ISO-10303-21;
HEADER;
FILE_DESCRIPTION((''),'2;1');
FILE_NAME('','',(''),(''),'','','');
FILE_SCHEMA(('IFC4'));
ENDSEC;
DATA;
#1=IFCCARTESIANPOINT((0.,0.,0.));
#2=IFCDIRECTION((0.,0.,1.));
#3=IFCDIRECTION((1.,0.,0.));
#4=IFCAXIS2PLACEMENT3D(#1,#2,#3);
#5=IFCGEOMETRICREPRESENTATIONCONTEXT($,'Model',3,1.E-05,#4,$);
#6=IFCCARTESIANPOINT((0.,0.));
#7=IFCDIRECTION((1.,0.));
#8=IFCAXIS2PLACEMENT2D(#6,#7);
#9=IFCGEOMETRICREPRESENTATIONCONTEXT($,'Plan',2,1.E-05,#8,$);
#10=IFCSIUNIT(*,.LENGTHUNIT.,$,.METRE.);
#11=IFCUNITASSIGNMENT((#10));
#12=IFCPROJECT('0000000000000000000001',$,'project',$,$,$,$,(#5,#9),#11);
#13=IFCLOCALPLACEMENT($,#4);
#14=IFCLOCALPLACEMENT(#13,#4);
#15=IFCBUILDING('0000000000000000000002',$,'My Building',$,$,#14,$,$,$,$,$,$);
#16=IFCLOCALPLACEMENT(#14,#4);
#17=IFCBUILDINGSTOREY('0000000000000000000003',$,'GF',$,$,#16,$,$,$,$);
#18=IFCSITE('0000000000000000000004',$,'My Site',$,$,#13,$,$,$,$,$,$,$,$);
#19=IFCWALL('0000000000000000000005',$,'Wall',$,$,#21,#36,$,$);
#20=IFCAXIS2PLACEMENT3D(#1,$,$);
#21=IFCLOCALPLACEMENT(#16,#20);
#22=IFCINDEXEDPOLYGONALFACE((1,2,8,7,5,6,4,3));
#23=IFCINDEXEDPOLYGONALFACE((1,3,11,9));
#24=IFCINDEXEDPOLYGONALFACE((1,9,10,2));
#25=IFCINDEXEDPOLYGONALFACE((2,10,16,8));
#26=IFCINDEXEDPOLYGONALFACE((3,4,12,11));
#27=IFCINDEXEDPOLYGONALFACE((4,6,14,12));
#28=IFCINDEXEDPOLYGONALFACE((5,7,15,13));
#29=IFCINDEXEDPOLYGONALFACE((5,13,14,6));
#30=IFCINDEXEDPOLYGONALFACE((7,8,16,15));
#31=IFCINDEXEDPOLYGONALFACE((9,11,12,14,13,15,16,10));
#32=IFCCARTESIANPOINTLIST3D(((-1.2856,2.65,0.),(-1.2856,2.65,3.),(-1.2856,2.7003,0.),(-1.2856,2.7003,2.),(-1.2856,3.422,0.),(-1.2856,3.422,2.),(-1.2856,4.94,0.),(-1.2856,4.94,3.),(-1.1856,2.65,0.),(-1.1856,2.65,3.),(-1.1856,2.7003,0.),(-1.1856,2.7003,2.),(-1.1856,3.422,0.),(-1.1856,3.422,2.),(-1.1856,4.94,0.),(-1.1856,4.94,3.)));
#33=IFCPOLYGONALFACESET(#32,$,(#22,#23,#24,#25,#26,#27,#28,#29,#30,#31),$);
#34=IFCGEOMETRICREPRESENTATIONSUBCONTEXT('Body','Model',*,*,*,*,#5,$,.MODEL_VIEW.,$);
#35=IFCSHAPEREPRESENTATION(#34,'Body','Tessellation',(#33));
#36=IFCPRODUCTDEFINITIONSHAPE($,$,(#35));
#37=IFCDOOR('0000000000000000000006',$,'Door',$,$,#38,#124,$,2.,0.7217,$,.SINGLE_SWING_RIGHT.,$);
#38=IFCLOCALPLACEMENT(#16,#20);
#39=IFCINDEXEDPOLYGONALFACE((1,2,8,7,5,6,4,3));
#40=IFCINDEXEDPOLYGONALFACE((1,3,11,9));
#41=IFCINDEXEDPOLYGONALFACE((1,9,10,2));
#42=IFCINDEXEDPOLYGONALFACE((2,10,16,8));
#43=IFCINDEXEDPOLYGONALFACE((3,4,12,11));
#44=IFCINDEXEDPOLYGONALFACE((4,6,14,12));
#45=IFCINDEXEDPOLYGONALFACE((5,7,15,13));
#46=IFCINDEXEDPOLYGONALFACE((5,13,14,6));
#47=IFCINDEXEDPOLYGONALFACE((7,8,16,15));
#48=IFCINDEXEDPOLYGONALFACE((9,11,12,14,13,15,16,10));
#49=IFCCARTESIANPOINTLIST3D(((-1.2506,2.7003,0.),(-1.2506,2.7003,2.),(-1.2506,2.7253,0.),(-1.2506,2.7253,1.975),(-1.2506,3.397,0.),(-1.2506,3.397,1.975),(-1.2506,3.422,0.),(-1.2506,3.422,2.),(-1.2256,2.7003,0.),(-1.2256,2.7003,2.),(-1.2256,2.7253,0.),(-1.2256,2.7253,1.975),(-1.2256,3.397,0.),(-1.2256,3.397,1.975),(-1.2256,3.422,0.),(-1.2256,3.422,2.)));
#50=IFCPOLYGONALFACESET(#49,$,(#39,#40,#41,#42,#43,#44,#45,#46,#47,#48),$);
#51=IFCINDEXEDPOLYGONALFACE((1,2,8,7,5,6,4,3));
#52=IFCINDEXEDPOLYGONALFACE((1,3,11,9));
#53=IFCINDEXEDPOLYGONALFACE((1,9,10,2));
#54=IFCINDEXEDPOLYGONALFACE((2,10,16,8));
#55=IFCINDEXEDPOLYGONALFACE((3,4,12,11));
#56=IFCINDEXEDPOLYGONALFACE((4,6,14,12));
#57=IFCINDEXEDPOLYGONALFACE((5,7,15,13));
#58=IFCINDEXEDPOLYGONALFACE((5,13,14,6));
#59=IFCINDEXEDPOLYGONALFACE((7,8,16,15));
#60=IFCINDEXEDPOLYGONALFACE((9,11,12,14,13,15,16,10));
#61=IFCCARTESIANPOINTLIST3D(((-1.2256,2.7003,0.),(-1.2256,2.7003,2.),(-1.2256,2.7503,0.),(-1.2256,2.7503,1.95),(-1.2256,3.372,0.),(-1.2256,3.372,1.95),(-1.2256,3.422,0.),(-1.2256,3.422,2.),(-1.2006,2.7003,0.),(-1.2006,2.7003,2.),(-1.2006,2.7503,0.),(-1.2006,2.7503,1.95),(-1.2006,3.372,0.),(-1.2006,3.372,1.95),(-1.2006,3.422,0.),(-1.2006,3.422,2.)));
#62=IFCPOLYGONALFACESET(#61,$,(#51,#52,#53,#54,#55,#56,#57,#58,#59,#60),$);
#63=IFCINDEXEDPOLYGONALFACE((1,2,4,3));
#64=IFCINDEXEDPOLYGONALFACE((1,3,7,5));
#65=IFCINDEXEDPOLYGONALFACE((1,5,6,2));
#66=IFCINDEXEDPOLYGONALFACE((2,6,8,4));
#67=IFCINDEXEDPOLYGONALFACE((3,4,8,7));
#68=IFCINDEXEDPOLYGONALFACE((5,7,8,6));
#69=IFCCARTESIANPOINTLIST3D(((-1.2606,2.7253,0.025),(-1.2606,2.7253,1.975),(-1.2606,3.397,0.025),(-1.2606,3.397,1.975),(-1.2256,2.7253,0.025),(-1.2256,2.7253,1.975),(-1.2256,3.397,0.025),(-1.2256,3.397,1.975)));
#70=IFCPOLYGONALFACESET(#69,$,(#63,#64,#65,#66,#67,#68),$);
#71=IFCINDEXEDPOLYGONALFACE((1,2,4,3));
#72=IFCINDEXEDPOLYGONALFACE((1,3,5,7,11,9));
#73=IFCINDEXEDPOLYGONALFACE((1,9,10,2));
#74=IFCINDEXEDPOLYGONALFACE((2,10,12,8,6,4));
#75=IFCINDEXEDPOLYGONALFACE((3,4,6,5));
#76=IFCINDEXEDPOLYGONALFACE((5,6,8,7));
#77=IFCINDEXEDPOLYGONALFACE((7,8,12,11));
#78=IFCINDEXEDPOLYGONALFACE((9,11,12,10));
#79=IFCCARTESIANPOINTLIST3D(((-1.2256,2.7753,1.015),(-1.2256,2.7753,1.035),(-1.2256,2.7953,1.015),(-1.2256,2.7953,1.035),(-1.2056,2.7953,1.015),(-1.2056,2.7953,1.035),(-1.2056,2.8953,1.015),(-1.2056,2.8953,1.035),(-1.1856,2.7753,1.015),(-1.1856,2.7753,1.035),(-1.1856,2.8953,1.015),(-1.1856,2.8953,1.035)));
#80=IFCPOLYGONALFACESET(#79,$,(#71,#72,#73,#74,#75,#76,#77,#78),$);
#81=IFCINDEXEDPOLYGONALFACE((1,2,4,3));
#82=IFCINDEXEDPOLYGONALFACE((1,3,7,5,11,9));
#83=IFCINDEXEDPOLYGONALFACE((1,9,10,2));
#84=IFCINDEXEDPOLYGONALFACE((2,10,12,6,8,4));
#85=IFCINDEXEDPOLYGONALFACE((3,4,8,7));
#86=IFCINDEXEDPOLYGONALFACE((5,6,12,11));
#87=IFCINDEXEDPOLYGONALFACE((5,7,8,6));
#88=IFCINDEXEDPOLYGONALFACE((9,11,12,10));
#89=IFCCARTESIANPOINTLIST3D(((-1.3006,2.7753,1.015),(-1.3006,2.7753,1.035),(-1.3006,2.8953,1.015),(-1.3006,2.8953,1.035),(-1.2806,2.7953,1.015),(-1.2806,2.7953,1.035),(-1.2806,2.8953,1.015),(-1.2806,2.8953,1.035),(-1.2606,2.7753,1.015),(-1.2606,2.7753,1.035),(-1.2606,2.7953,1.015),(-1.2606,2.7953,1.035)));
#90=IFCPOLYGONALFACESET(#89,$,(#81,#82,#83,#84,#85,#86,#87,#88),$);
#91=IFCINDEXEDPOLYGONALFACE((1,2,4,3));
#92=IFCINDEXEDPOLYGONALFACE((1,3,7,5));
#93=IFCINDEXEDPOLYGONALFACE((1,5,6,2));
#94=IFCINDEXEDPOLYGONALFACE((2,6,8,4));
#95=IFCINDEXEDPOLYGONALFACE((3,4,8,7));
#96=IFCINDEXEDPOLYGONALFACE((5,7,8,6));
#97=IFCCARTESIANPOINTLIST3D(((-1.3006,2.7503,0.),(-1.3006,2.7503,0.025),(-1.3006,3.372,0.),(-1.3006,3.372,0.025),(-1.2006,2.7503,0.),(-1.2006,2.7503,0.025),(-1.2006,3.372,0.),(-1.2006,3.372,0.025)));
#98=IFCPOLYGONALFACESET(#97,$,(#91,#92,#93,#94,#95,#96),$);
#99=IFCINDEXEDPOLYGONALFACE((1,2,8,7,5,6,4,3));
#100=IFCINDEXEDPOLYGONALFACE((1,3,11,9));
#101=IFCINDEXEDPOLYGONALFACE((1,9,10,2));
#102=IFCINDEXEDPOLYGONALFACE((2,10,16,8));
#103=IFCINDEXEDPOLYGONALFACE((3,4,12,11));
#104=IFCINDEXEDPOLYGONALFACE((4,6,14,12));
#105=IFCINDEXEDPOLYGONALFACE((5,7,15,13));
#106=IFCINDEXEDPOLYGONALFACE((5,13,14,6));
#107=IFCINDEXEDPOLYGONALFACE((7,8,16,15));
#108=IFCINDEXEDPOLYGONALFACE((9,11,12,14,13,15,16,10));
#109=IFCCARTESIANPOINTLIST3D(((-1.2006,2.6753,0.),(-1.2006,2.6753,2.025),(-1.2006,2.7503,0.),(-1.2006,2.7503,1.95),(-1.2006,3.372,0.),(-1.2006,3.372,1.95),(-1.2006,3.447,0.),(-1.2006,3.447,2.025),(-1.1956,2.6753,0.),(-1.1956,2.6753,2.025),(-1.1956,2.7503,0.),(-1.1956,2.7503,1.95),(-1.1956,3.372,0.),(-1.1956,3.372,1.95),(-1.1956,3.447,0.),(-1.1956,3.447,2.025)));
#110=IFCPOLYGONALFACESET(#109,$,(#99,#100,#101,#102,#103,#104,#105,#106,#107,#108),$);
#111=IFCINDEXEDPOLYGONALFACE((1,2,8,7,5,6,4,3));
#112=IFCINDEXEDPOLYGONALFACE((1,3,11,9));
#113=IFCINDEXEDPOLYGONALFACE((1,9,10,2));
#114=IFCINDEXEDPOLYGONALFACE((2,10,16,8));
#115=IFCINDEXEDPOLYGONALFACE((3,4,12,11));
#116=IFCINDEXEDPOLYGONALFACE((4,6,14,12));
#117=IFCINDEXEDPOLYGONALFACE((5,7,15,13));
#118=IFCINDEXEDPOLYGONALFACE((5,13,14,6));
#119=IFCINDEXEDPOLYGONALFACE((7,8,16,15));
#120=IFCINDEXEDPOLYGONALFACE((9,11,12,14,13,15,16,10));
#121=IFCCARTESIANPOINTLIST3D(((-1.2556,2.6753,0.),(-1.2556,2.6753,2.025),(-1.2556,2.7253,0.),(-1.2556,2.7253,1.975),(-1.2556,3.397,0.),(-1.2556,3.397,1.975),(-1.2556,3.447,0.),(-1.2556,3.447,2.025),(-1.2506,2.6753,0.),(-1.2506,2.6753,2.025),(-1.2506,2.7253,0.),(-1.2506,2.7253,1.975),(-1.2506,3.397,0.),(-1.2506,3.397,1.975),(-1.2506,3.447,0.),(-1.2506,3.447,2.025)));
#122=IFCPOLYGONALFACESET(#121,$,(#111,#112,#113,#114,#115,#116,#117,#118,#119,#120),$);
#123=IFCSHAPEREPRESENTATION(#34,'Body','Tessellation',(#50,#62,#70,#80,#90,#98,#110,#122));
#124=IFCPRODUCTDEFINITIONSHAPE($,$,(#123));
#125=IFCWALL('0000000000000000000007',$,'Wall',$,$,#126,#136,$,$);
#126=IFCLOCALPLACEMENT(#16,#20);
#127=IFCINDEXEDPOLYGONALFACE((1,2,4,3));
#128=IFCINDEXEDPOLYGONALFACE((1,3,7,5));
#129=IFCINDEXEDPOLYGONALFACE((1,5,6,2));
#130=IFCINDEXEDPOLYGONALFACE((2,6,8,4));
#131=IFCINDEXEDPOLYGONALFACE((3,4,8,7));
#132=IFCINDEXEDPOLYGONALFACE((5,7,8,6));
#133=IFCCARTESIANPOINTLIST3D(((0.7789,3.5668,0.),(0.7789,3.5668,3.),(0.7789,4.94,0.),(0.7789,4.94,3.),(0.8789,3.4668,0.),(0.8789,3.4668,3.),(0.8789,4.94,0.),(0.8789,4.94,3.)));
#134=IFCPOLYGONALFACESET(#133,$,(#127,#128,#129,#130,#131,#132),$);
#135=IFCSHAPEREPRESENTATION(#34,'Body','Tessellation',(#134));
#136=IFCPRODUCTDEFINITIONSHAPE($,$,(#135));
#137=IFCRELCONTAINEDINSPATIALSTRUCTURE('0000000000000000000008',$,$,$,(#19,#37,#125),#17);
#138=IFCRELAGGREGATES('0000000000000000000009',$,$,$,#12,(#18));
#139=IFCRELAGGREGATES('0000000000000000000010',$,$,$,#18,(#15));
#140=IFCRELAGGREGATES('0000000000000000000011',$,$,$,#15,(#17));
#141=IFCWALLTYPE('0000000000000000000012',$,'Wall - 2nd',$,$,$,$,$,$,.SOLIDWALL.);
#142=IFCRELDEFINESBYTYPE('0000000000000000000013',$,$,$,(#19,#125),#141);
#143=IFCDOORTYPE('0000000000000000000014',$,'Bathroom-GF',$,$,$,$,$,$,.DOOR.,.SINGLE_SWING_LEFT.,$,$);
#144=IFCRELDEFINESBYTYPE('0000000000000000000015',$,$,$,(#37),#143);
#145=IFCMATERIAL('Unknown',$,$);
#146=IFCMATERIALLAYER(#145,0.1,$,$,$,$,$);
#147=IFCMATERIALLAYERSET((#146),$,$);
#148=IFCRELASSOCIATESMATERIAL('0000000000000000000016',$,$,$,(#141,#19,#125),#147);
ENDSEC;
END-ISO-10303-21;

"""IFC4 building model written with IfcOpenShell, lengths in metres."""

from ifc_helpers import new_model, entity, si_unit, frame, origin_with_axes, origin_2d_with_axis, place, context, subcontext, project, spatial, line, indexed_curve, outline, extrude, shape, source, transform, mapped, material, layer, layer_set, layer_usage, type_object, type_shapes, element, fill, save


model = new_model("IFC4")

# Units and contexts
model_context = context("Model", 3, precision=1e-05, world=origin_with_axes())
plan_context = context("Plan", 2, precision=1e-05, world=origin_2d_with_axis())
body_context_1 = subcontext(model_context, "Body", "Model", "MODEL_VIEW")
body_context_2 = subcontext(plan_context, "Body", "Plan", "PLAN_VIEW")
ifc_project = project(units=[si_unit("LENGTHUNIT", "METRE")], contexts=[model_context, plan_context])

# Site, building, storey
site_placement = place(None, origin_with_axes())
site = spatial("IfcSite", under=ifc_project, at=site_placement, Name="My Site")
building_placement = place(site_placement, origin_with_axes())
building = spatial("IfcBuilding", under=site, at=building_placement, Name="My Building")
storey_placement = place(building_placement, origin_with_axes())
storey = spatial("IfcBuildingStorey", under=building, at=storey_placement, Name="GF")

# Shared definitions
ifc_material = material(Name="Unknown")

# Shared definitions
ifc_layer_1 = layer(ifc_material, 0.1)
ifc_layer_set_1 = layer_set([ifc_layer_1])
wall_type = type_object("IfcWallType", Name="Wall - 2nd", PredefinedType="SOLIDWALL", material=ifc_layer_set_1)

# Wall, opening, door
ifc_layer_usage_1 = layer_usage(ifc_layer_set_1, "AXIS2", "POSITIVE", 0.0)
wall_1_placement = place(storey_placement, frame((-1.1856, 2.65, 0.0), z_axis=(0.0, 0.0, 1.0), x_axis=(0.0, 1.0, 0.0)))
wall_1 = element("IfcWall", 1, at=wall_1_placement, inside=storey, type_object=wall_type, material=ifc_layer_usage_1, Name="Wall", context=body_context_1, shape_type="SweptSolid", body=[
    extrude(outline(indexed_curve([(0.0, 0.0), (0.0, 0.1), (2.29, 0.1), (2.29, 0.0)], segments=[line(1, 2, 3, 4, 1)])), origin_with_axes(), (0.0, 0.0, 1.0), 3.0),
])
shared_shape_1 = source(origin_with_axes(), body_context_1, "Body", "SweptSolid", [
    extrude(outline(indexed_curve([(0.0, 0.0), (0.7217, 0.0), (0.7217, 2.0), (0.0, 2.0)], segments=[line(1, 2, 3, 4, 1)])), frame((0.0, -0.6, 0.0), z_axis=(0.0, -1.0, 0.0), x_axis=(1.0, 0.0, 0.0)), (0.0, 0.0, -1.0), 1.2),
])
opening_1_placement = place(wall_1_placement, frame((0.772, 0.1, 0.0), z_axis=(0.0, 0.0, 1.0), x_axis=(-1.0, 0.0, 0.0)))
opening_1 = element("IfcOpeningElement", 2, at=opening_1_placement, cuts=wall_1, PredefinedType="OPENING", context=body_context_1, shape_type="MappedRepresentation", body=[
    mapped(shared_shape_1, transform((0.0, 0.0, 0.0), x_axis=(1.0, 0.0, 0.0), y_axis=(0.0, 1.0, 0.0), z_axis=(0.0, 0.0, 1.0), scale=1.0)),
])
door_type_1 = type_object("IfcDoorType", Name="Bathroom-GF", OperationType="SINGLE_SWING_LEFT", PredefinedType="DOOR")
shared_shape_2 = source(origin_with_axes(), body_context_1, "Body", "SweptSolid", [
    extrude(outline(indexed_curve([(0.0, 0.0), (0.0, 2.0), (0.7217, 2.0), (0.7217, 0.0), (0.6967, 0.0), (0.6967, 1.975), (0.025, 1.975), (0.025, 0.0)], segments=[line(1, 2, 3, 4, 5, 6, 7, 8, 1)])), frame((0.0, 0.025, 0.0), z_axis=(0.0, -1.0, 0.0), x_axis=(1.0, 0.0, 0.0)), (0.0, 0.0, -1.0), 0.025),
    extrude(outline(indexed_curve([(0.0, 0.0), (0.0, 2.0), (0.7217, 2.0), (0.7217, 0.0), (0.6717, 0.0), (0.6717, 1.95), (0.05, 1.95), (0.05, 0.0)], segments=[line(1, 2, 3, 4, 5, 6, 7, 8, 1)])), frame((0.0, 0.0, 0.0), z_axis=(0.0, -1.0, 0.0), x_axis=(1.0, 0.0, 0.0)), (0.0, 0.0, -1.0), 0.025),
    extrude(outline(indexed_curve([(0.0, 0.0), (0.6717, 0.0), (0.6717, 0.035), (0.0, 0.035)], segments=[line(1, 2, 3, 4, 1)])), frame((0.025, 0.025, 0.025), z_axis=(0.0, 0.0, 1.0), x_axis=(1.0, 0.0, 0.0)), (0.0, 0.0, 1.0), 1.95),
    extrude(outline(indexed_curve([(0.0, 0.0), (0.0, -0.04), (0.12, -0.04), (0.12, -0.02), (0.02, -0.02), (0.02, 0.0)], segments=[line(1, 2, 3, 4, 5, 6, 1)])), frame((0.075, 0.025, 1.015), z_axis=(0.0, 0.0, 1.0), x_axis=(1.0, 0.0, 0.0)), (0.0, 0.0, 1.0), 0.02),
    extrude(outline(indexed_curve([(0.0, 0.0), (0.0, 0.04), (0.12, 0.04), (0.12, 0.02), (0.02, 0.02), (0.02, 0.0)], segments=[line(1, 2, 3, 4, 5, 6, 1)])), frame((0.075, 0.06, 1.015), z_axis=(0.0, 0.0, 1.0), x_axis=(1.0, 0.0, 0.0)), (0.0, 0.0, 1.0), 0.02),
    extrude(outline(indexed_curve([(0.0, 0.0), (0.6217, 0.0), (0.6217, 0.1), (0.0, 0.1)], segments=[line(1, 2, 3, 4, 1)])), frame((0.05, 0.0, 0.0), z_axis=(0.0, 0.0, 1.0), x_axis=(1.0, 0.0, 0.0)), (0.0, 0.0, 1.0), 0.025),
    extrude(outline(indexed_curve([(0.0, 0.0), (0.0, 2.025), (0.7717, 2.025), (0.7717, 0.0), (0.6967, 0.0), (0.6967, 1.95), (0.075, 1.95), (0.075, 0.0)], segments=[line(1, 2, 3, 4, 5, 6, 7, 8, 1)])), frame((-0.025, -0.005, 0.0), z_axis=(0.0, -1.0, 0.0), x_axis=(1.0, 0.0, 0.0)), (0.0, 0.0, -1.0), 0.005),
    extrude(outline(indexed_curve([(0.0, 0.0), (0.0, 2.025), (0.7717, 2.025), (0.7717, 0.0), (0.7217, 0.0), (0.7217, 1.975), (0.05, 1.975), (0.05, 0.0)], segments=[line(1, 2, 3, 4, 5, 6, 7, 8, 1)])), frame((-0.025, 0.05, 0.0), z_axis=(0.0, -1.0, 0.0), x_axis=(1.0, 0.0, 0.0)), (0.0, 0.0, -1.0), 0.005),
])
shared_shape_3 = source(origin_with_axes(), body_context_2, "Body", "Curve2D", [
    entity("IfcIndexedPolyCurve", entity("IfcCartesianPointList2D", [[0.0, 0.0], [0.0, 0.05], [0.025, 0.05], [0.025, 0.025], [0.05, 0.025], [0.05, 0.0]]), [entity("IfcLineIndex", [1, 2, 3, 4, 5, 6, 1])]),
    entity("IfcIndexedPolyCurve", entity("IfcCartesianPointList2D", [[0.7217, 0.0], [0.7217, 0.05], [0.6967, 0.05], [0.6967, 0.025], [0.6717, 0.025], [0.6717, 0.0]]), [entity("IfcLineIndex", [1, 2, 3, 4, 5, 6, 1])]),
    entity("IfcTrimmedCurve", entity("IfcEllipse", entity("IfcAxis2Placement2D", entity("IfcCartesianPoint", [0.6617, 0.05]), entity("IfcDirection", [1.0, 0.0])), 0.6367, 0.6717), [entity("IfcCartesianPoint", [0.6617, 0.7217])], [entity("IfcCartesianPoint", [0.025, 0.05])], True, "CARTESIAN"),
    entity("IfcIndexedPolyCurve", entity("IfcCartesianPointList2D", [[0.6967, 0.05], [0.6617, 0.05], [0.6617, 0.7217], [0.6967, 0.7217]]), [entity("IfcLineIndex", [1, 2, 3, 4, 1])]),
])
type_shapes(door_type_1, [shared_shape_2, shared_shape_3])
door_1_placement = place(opening_1_placement, frame((0.7217, 0.085, 0.0), z_axis=(0.0, 0.0, 1.0), x_axis=(-1.0, 0.0, 0.0)))
door_1 = element("IfcDoor", 3, at=door_1_placement, inside=storey, type_object=door_type_1, Name="Door", OperationType="SINGLE_SWING_RIGHT", OverallHeight=2.0, OverallWidth=0.7217, shapes=[
    shape(body_context_1, "Body", "MappedRepresentation", [mapped(shared_shape_2, transform((0.0, 0.0, 0.0), x_axis=(1.0, 0.0, 0.0), y_axis=(0.0, 1.0, 0.0), z_axis=(0.0, 0.0, 1.0), scale=1.0))]),
    shape(body_context_2, "Body", "MappedRepresentation", [mapped(shared_shape_3, transform((0.0, 0.0, 0.0), x_axis=(1.0, 0.0, 0.0), y_axis=(0.0, 1.0, 0.0), z_axis=(0.0, 0.0, 1.0), scale=1.0))]),
])
fill(opening_1, door_1)

# Wall
ifc_layer_usage_2 = layer_usage(ifc_layer_set_1, "AXIS2", "POSITIVE", 0.0)
wall_2_placement = place(storey_placement, frame((0.7789, 5.04, 0.0), z_axis=(0.0, 0.0, 1.0), x_axis=(0.0, -1.0, 0.0)))
element("IfcWall", 4, at=wall_2_placement, inside=storey, type_object=wall_type, material=ifc_layer_usage_2, Name="Wall", context=body_context_1, shape_type="SweptSolid", body=[
    extrude(outline(indexed_curve([(0.1, 0.0), (0.1, 0.1), (1.5732, 0.1), (1.4732, 0.0)], segments=[line(1, 2, 3, 4, 1)])), origin_with_axes(), (0.0, 0.0, 1.0), 3.0),
])

save(model, "model.ifc")
